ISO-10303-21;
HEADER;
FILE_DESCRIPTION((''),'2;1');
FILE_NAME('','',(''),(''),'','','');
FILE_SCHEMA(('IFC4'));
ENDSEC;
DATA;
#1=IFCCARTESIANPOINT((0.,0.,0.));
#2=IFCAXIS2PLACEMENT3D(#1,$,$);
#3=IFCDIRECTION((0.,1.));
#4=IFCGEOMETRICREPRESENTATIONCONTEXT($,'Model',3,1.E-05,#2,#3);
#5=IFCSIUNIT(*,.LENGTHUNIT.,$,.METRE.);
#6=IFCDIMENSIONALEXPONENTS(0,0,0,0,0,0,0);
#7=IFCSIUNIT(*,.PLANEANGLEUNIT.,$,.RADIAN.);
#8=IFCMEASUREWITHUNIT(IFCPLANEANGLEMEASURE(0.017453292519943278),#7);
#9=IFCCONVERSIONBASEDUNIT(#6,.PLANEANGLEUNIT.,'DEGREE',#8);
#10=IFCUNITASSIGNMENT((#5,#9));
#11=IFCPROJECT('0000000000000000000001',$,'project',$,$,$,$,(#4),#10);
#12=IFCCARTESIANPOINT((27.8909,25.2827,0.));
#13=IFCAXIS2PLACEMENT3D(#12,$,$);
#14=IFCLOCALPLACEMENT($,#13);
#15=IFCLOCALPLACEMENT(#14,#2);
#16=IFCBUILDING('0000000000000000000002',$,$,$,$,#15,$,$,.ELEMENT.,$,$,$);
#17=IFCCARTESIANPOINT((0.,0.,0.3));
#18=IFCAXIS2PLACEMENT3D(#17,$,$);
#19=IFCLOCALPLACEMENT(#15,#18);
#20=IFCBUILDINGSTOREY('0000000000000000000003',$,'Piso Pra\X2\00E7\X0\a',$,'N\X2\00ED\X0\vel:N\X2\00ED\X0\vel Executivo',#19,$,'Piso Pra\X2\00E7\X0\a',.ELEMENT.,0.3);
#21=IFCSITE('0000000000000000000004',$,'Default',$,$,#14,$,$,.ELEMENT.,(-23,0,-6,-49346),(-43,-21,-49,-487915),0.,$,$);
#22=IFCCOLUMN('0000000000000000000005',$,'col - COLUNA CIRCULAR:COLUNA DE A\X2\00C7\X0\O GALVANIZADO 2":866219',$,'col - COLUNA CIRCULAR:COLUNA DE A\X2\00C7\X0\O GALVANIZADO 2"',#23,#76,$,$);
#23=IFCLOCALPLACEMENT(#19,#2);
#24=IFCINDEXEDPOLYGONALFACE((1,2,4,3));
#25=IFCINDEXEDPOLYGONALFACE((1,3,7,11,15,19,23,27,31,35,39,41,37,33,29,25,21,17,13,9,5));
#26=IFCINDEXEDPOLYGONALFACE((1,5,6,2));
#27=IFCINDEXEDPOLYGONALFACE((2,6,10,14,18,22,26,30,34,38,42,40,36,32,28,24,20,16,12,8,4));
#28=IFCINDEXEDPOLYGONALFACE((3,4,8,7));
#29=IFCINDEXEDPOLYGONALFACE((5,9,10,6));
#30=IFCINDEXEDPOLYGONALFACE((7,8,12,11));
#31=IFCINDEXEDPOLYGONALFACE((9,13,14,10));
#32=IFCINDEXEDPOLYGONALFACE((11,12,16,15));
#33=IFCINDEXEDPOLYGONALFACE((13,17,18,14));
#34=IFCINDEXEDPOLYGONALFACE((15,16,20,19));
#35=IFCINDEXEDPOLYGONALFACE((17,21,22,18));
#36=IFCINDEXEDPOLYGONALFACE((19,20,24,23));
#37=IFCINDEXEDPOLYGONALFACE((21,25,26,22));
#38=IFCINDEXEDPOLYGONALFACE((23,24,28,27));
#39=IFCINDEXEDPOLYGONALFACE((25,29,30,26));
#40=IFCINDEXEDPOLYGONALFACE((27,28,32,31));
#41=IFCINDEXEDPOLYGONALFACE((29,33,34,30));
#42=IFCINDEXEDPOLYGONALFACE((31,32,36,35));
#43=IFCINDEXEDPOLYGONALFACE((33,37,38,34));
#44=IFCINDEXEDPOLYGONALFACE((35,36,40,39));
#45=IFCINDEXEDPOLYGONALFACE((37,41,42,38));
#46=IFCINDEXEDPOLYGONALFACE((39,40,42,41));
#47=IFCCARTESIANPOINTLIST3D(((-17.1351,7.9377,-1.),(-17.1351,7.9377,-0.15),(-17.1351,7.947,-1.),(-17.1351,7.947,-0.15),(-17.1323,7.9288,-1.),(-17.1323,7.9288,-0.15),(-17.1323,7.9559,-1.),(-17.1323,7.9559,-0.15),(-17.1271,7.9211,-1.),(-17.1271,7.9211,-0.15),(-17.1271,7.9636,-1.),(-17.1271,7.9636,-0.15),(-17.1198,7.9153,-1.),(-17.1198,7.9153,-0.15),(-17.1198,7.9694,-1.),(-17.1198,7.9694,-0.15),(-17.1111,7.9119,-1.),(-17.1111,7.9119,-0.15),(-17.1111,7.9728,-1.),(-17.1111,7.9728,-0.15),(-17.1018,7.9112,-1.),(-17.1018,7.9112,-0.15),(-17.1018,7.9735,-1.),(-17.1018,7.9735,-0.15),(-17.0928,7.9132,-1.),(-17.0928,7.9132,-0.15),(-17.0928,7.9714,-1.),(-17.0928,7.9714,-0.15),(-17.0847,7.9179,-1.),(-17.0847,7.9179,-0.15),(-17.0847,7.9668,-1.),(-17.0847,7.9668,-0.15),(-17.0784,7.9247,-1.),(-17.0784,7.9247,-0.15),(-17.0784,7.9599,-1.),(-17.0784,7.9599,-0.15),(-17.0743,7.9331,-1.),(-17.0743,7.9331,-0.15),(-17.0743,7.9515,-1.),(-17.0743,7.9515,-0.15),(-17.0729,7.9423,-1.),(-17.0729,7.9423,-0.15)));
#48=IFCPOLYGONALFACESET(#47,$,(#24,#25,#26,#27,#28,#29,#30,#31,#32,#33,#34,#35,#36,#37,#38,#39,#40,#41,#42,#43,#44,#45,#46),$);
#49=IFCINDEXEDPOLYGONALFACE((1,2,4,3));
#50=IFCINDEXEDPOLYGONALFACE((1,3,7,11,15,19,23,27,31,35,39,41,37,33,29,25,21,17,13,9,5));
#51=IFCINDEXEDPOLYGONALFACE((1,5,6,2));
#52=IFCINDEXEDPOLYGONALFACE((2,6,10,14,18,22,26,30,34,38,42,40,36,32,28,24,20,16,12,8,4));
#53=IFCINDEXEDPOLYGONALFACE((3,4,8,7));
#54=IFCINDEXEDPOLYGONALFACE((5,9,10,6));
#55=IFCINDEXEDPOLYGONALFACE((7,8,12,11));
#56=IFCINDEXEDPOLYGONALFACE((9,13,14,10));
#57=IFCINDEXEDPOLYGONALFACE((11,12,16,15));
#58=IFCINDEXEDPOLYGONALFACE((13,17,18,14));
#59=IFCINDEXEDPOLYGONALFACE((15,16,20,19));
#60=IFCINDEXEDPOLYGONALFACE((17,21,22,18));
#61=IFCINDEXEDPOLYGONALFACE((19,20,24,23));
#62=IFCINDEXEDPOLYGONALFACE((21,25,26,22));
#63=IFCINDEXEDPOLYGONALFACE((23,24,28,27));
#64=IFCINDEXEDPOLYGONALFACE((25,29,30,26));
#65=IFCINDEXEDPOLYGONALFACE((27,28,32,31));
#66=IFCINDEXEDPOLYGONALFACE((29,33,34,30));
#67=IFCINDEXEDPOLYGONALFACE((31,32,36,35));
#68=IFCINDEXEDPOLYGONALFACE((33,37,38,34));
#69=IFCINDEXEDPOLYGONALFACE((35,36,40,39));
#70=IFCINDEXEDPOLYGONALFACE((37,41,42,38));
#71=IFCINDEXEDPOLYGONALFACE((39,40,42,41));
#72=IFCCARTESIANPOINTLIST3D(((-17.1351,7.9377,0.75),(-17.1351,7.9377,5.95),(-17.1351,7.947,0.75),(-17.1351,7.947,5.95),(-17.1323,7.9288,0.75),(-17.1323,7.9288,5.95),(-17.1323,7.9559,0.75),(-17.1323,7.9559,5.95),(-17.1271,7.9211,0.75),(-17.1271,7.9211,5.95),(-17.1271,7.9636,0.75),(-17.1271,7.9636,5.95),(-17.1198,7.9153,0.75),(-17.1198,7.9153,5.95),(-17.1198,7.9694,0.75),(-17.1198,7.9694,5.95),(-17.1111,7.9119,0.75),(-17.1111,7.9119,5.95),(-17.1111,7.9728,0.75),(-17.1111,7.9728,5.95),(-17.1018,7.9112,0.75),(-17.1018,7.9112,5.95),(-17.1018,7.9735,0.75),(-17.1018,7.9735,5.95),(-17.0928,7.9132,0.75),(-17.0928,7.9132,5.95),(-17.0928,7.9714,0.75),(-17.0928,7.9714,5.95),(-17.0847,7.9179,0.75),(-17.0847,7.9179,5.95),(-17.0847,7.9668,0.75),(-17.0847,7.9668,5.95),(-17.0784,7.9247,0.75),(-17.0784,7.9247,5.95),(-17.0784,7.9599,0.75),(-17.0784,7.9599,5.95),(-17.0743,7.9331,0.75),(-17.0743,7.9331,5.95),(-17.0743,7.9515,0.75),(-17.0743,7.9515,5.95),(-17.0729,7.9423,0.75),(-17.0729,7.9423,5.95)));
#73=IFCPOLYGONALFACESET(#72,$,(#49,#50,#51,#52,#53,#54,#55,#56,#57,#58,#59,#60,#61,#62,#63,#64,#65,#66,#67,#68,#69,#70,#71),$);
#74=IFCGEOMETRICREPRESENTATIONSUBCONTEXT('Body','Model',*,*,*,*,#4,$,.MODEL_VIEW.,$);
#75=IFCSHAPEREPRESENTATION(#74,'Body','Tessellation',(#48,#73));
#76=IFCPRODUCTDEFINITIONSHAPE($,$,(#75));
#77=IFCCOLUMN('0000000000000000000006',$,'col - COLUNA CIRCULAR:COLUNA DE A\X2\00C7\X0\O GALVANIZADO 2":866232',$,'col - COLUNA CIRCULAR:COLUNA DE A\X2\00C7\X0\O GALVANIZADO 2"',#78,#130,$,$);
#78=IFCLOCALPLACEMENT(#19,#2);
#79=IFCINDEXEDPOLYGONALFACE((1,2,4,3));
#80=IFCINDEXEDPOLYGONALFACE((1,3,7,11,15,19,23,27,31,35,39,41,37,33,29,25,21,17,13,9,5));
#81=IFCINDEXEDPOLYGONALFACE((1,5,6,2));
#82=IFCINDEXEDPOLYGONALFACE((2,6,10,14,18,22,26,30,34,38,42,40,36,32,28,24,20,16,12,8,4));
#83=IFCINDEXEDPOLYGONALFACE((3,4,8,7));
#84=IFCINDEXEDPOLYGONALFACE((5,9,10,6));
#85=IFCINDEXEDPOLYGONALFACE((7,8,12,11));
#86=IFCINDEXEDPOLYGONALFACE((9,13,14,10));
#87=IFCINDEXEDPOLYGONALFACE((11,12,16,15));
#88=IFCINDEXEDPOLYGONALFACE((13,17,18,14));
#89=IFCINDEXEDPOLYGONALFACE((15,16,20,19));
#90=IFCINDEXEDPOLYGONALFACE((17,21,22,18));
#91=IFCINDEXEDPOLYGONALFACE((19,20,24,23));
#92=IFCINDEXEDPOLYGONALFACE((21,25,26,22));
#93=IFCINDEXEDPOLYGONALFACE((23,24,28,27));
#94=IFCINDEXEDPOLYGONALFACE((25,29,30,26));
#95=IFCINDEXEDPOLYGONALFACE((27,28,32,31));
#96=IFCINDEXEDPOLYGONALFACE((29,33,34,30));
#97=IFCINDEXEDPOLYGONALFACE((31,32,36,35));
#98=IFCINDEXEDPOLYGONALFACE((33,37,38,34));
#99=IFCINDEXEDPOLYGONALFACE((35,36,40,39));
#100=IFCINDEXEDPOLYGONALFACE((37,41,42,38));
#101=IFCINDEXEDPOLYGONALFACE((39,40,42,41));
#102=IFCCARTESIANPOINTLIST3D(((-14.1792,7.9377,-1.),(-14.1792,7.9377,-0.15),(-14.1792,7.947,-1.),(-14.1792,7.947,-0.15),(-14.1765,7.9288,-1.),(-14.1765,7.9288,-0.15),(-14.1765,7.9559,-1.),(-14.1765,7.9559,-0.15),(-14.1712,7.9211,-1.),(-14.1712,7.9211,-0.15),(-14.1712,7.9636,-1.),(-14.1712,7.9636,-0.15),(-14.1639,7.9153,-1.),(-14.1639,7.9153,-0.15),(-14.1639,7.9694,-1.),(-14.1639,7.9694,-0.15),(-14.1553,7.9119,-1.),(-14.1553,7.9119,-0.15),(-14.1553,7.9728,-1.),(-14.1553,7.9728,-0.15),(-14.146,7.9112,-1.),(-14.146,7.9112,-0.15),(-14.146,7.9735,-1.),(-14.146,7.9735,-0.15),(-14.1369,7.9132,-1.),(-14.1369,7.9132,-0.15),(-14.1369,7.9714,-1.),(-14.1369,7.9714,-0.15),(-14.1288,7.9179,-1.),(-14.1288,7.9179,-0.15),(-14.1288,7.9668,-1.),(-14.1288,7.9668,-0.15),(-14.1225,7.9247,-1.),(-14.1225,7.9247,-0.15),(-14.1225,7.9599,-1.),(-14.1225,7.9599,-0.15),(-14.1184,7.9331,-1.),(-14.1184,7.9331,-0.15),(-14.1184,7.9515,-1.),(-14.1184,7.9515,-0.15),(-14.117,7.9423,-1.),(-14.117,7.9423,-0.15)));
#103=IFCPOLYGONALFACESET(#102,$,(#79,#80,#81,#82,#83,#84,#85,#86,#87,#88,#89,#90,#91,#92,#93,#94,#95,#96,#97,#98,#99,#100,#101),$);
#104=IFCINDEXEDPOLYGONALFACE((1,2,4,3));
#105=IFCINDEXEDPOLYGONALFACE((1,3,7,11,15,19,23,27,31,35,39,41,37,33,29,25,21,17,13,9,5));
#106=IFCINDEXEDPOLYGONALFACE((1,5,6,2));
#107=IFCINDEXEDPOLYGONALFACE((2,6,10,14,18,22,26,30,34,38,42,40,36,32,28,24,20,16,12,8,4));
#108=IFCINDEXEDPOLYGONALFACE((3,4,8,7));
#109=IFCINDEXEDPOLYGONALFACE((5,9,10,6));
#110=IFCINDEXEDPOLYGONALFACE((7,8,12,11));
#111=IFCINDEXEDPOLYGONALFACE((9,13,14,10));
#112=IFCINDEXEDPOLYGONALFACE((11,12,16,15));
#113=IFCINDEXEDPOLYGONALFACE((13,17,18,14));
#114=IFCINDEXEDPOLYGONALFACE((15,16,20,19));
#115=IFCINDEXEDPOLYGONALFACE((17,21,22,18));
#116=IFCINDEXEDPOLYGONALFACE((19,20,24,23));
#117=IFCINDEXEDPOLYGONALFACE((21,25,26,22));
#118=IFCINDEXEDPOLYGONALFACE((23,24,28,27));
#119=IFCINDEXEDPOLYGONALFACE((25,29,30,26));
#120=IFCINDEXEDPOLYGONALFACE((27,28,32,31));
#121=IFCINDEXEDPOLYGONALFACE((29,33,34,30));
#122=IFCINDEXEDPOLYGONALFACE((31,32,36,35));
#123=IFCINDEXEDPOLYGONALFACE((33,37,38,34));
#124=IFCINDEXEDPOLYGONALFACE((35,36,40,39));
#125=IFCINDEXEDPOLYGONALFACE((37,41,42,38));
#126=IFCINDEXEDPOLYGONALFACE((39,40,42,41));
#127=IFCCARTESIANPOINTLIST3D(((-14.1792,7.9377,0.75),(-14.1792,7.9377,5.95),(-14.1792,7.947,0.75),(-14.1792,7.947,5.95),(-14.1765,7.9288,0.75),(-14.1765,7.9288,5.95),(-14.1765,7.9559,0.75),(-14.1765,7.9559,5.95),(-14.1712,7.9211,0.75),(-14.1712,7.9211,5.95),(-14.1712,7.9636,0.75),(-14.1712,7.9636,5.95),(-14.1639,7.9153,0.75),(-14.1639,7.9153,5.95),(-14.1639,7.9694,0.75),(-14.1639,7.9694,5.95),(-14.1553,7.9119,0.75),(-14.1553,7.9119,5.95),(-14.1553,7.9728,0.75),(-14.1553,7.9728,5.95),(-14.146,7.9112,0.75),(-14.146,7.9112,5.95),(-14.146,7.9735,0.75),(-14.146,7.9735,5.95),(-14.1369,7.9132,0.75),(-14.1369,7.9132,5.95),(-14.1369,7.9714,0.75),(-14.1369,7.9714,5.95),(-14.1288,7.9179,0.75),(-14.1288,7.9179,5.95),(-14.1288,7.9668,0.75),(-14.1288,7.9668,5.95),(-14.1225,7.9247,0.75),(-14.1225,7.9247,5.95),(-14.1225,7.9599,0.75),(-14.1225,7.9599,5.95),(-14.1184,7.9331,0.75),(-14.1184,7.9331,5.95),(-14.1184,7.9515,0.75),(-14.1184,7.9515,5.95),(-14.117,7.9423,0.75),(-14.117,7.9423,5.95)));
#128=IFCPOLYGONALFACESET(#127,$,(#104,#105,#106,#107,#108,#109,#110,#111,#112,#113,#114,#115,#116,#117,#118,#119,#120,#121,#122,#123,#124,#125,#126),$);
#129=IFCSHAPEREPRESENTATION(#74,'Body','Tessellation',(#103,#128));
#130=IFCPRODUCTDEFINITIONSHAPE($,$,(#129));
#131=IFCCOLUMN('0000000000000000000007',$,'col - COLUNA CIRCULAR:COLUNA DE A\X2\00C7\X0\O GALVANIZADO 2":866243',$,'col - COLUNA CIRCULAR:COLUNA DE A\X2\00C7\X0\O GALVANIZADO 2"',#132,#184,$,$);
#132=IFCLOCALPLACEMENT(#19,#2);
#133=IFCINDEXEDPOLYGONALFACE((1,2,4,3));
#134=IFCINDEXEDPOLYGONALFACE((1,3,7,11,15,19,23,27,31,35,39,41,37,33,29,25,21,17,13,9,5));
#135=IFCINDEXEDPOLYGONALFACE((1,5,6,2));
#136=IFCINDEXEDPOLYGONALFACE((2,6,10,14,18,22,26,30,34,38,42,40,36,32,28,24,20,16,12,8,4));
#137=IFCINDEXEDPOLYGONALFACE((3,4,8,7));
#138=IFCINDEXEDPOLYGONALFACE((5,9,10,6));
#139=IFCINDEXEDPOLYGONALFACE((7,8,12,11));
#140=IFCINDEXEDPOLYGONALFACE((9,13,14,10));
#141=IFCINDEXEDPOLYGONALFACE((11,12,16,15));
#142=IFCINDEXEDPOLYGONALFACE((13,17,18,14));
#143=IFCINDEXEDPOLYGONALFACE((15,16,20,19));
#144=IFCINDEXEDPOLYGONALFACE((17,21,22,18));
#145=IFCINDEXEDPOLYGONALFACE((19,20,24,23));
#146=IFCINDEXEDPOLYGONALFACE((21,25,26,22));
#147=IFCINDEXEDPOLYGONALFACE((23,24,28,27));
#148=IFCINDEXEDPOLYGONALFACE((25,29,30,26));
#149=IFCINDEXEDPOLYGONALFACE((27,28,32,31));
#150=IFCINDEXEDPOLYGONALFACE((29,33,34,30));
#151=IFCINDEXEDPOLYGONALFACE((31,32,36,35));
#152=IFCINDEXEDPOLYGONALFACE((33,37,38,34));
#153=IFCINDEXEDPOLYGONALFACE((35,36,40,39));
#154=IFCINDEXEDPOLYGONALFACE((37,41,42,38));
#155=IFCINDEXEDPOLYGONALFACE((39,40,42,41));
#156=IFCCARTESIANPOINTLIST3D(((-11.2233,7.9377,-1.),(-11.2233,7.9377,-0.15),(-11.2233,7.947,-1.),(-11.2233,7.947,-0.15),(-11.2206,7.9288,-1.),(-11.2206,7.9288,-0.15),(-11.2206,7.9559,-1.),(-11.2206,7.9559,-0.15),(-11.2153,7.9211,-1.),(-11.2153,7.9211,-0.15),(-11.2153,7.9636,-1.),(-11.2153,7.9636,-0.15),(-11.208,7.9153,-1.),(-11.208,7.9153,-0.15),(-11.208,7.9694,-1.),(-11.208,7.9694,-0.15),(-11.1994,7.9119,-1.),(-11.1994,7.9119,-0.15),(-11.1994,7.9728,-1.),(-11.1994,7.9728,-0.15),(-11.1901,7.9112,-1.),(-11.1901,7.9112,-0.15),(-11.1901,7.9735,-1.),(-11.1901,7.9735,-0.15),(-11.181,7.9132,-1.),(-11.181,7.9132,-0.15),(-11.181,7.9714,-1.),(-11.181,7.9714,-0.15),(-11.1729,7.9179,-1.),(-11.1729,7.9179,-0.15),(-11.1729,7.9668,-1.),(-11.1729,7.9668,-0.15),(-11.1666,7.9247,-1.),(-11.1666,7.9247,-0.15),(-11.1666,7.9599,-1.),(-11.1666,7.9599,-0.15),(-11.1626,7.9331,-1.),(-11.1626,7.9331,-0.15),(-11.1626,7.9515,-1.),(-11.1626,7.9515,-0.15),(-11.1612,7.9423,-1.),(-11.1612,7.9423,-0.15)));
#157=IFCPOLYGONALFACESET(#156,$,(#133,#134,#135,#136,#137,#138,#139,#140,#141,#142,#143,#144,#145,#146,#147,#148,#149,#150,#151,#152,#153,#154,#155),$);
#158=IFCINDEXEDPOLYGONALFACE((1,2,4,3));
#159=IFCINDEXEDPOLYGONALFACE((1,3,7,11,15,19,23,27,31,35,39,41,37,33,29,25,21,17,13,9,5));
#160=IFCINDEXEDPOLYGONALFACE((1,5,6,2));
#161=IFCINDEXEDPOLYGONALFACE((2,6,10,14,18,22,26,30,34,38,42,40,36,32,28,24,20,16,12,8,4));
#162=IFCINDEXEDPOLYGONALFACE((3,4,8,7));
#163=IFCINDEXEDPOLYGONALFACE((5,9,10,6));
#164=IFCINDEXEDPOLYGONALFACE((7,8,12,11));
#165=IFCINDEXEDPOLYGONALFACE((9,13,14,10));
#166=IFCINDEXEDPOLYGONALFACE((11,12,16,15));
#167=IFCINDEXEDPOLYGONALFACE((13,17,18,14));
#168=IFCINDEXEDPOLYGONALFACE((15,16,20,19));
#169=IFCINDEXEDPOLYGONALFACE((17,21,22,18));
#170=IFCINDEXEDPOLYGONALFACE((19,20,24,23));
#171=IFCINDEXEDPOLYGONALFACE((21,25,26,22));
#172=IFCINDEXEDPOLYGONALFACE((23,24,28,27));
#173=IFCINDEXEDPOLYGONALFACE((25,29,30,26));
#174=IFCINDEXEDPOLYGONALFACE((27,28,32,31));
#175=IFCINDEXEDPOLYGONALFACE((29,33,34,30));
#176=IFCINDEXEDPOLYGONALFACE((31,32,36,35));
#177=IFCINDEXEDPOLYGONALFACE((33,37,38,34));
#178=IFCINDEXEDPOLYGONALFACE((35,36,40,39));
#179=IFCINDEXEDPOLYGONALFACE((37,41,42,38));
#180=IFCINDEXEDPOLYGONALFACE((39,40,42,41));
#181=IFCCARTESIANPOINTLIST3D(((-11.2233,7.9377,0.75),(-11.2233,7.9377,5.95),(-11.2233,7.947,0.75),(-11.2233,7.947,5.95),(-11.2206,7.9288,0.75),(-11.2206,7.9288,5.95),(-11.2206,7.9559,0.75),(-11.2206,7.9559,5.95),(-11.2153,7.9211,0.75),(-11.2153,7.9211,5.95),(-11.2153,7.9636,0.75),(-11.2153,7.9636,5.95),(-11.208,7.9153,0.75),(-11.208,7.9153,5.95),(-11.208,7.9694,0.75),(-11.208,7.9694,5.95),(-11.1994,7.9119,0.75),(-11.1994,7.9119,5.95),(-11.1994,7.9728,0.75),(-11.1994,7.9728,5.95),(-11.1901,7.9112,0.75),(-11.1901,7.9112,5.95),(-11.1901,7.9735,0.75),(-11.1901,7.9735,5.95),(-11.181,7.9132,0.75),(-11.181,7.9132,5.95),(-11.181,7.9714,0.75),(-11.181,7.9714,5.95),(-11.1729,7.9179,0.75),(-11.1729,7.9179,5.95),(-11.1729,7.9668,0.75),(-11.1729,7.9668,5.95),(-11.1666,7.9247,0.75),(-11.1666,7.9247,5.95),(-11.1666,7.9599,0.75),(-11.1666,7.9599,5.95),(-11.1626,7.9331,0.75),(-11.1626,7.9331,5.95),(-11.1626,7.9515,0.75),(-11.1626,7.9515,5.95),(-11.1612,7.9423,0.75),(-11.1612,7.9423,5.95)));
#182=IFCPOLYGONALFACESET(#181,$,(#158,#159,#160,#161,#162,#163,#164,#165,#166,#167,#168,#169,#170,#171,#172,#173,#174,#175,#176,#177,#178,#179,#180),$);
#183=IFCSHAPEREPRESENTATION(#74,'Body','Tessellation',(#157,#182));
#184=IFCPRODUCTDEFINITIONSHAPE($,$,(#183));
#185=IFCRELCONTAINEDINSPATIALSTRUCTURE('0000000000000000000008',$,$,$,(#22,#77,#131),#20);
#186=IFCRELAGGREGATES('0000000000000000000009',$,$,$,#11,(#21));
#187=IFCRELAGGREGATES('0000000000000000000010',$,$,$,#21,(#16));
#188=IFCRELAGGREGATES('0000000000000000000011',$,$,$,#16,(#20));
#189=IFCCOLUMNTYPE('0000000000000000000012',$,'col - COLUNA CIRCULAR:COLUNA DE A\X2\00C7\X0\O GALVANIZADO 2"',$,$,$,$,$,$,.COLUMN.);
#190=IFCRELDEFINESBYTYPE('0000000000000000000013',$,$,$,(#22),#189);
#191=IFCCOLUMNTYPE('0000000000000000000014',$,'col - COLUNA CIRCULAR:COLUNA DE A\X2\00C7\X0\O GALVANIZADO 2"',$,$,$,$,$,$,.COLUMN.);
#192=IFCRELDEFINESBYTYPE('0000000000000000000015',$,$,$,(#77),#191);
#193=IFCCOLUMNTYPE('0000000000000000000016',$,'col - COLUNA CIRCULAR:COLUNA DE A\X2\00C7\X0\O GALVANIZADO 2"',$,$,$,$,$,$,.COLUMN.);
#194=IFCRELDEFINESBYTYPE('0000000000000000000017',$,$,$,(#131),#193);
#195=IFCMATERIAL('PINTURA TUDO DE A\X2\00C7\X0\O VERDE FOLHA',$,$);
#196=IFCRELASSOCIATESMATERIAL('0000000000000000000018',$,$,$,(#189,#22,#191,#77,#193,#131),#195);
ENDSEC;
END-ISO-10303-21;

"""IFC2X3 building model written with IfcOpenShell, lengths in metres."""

from ifc_helpers import new_model, entity, si_unit, converted_unit, direction, frame, origin, origin_2d_with_axis, place, context, subcontext, project, spatial, circle, extrude, source, transform, mapped, material, type_object, type_shapes, element, save


model = new_model("IFC2X3")

# Units and contexts
model_context = context("Model", 3, precision=1e-05, world=origin(), true_north=direction((0.0, 1.0)))
body_context = subcontext(model_context, "Body", "Model", "MODEL_VIEW")
ifc_project = project(units=[si_unit("LENGTHUNIT", "METRE"), converted_unit("PLANEANGLEUNIT", "DEGREE", entity("IfcPlaneAngleMeasure", 0.017453292519943278), si_unit("PLANEANGLEUNIT", "RADIAN"), dimensions=[0, 0, 0, 0, 0, 0, 0])], contexts=[model_context])

# Site, building, storey
site_placement = place(None, frame((27.8909, 25.2827, 0.0)))
site = spatial("IfcSite", under=ifc_project, at=site_placement, Name="Default", CompositionType="ELEMENT", RefLatitude=(-23, 0, -6, -49346), RefLongitude=(-43, -21, -49, -487915), RefElevation=0.0)
building_placement = place(site_placement, origin())
building = spatial("IfcBuilding", under=site, at=building_placement, CompositionType="ELEMENT")
storey_placement = place(building_placement, frame((0.0, 0.0, 0.3)))
storey = spatial("IfcBuildingStorey", under=building, at=storey_placement, Name="Piso Praça", ObjectType="Nível:Nível Executivo", LongName="Piso Praça", CompositionType="ELEMENT", Elevation=0.3)

# Columns
ifc_material_1 = material(Name="PINTURA TUDO DE AÇO VERDE FOLHA")
column_type_1 = type_object("IfcColumnType", Name="col - COLUNA CIRCULAR:COLUNA DE AÇO GALVANIZADO 2\"", PredefinedType="COLUMN", material=ifc_material_1)
shared_shape_1 = source(origin(), body_context, "Body", "SweptSolid", [
    extrude(circle(Radius=0.0312, at=origin_2d_with_axis()), frame((-17.1042, 7.9423, -0.7)), (0.0, 0.0, 1.0), 0.85),
    extrude(circle(Radius=0.0312, at=origin_2d_with_axis()), frame((-17.1042, 7.9423, 1.05)), (0.0, 0.0, 1.0), 5.2),
])
type_shapes(column_type_1, [shared_shape_1])
column_1_placement = place(storey_placement, frame((0.0, 0.0, -0.3)))
element("IfcColumn", 1, at=column_1_placement, inside=storey, type_object=column_type_1, material=ifc_material_1, Name="col - COLUNA CIRCULAR:COLUNA DE AÇO GALVANIZADO 2\":866219", ObjectType="col - COLUNA CIRCULAR:COLUNA DE AÇO GALVANIZADO 2\"", context=body_context, shape_type="MappedRepresentation", body=[
    mapped(shared_shape_1, transform((0.0, 0.0, 0.0), scale=1.0)),
])
column_type_2 = type_object("IfcColumnType", Name="col - COLUNA CIRCULAR:COLUNA DE AÇO GALVANIZADO 2\"", PredefinedType="COLUMN", material=ifc_material_1)
shared_shape_2 = source(origin(), body_context, "Body", "SweptSolid", [
    extrude(circle(Radius=0.0312, at=origin_2d_with_axis()), frame((-14.1483, 7.9423, -0.7)), (0.0, 0.0, 1.0), 0.85),
    extrude(circle(Radius=0.0312, at=origin_2d_with_axis()), frame((-14.1483, 7.9423, 1.05)), (0.0, 0.0, 1.0), 5.2),
])
type_shapes(column_type_2, [shared_shape_2])
column_2_placement = place(storey_placement, frame((0.0, 0.0, -0.3)))
element("IfcColumn", 2, at=column_2_placement, inside=storey, type_object=column_type_2, material=ifc_material_1, Name="col - COLUNA CIRCULAR:COLUNA DE AÇO GALVANIZADO 2\":866232", ObjectType="col - COLUNA CIRCULAR:COLUNA DE AÇO GALVANIZADO 2\"", context=body_context, shape_type="MappedRepresentation", body=[
    mapped(shared_shape_2, transform((0.0, 0.0, 0.0), scale=1.0)),
])
column_type_3 = type_object("IfcColumnType", Name="col - COLUNA CIRCULAR:COLUNA DE AÇO GALVANIZADO 2\"", PredefinedType="COLUMN", material=ifc_material_1)
shared_shape_3 = source(origin(), body_context, "Body", "SweptSolid", [
    extrude(circle(Radius=0.0312, at=origin_2d_with_axis()), frame((-11.1924, 7.9423, -0.7)), (0.0, 0.0, 1.0), 0.85),
    extrude(circle(Radius=0.0312, at=origin_2d_with_axis()), frame((-11.1924, 7.9423, 1.05)), (0.0, 0.0, 1.0), 5.2),
])
type_shapes(column_type_3, [shared_shape_3])
column_3_placement = place(storey_placement, frame((0.0, 0.0, -0.3)))
element("IfcColumn", 3, at=column_3_placement, inside=storey, type_object=column_type_3, material=ifc_material_1, Name="col - COLUNA CIRCULAR:COLUNA DE AÇO GALVANIZADO 2\":866243", ObjectType="col - COLUNA CIRCULAR:COLUNA DE AÇO GALVANIZADO 2\"", context=body_context, shape_type="MappedRepresentation", body=[
    mapped(shared_shape_3, transform((0.0, 0.0, 0.0), scale=1.0)),
])

save(model, "model.ifc")
